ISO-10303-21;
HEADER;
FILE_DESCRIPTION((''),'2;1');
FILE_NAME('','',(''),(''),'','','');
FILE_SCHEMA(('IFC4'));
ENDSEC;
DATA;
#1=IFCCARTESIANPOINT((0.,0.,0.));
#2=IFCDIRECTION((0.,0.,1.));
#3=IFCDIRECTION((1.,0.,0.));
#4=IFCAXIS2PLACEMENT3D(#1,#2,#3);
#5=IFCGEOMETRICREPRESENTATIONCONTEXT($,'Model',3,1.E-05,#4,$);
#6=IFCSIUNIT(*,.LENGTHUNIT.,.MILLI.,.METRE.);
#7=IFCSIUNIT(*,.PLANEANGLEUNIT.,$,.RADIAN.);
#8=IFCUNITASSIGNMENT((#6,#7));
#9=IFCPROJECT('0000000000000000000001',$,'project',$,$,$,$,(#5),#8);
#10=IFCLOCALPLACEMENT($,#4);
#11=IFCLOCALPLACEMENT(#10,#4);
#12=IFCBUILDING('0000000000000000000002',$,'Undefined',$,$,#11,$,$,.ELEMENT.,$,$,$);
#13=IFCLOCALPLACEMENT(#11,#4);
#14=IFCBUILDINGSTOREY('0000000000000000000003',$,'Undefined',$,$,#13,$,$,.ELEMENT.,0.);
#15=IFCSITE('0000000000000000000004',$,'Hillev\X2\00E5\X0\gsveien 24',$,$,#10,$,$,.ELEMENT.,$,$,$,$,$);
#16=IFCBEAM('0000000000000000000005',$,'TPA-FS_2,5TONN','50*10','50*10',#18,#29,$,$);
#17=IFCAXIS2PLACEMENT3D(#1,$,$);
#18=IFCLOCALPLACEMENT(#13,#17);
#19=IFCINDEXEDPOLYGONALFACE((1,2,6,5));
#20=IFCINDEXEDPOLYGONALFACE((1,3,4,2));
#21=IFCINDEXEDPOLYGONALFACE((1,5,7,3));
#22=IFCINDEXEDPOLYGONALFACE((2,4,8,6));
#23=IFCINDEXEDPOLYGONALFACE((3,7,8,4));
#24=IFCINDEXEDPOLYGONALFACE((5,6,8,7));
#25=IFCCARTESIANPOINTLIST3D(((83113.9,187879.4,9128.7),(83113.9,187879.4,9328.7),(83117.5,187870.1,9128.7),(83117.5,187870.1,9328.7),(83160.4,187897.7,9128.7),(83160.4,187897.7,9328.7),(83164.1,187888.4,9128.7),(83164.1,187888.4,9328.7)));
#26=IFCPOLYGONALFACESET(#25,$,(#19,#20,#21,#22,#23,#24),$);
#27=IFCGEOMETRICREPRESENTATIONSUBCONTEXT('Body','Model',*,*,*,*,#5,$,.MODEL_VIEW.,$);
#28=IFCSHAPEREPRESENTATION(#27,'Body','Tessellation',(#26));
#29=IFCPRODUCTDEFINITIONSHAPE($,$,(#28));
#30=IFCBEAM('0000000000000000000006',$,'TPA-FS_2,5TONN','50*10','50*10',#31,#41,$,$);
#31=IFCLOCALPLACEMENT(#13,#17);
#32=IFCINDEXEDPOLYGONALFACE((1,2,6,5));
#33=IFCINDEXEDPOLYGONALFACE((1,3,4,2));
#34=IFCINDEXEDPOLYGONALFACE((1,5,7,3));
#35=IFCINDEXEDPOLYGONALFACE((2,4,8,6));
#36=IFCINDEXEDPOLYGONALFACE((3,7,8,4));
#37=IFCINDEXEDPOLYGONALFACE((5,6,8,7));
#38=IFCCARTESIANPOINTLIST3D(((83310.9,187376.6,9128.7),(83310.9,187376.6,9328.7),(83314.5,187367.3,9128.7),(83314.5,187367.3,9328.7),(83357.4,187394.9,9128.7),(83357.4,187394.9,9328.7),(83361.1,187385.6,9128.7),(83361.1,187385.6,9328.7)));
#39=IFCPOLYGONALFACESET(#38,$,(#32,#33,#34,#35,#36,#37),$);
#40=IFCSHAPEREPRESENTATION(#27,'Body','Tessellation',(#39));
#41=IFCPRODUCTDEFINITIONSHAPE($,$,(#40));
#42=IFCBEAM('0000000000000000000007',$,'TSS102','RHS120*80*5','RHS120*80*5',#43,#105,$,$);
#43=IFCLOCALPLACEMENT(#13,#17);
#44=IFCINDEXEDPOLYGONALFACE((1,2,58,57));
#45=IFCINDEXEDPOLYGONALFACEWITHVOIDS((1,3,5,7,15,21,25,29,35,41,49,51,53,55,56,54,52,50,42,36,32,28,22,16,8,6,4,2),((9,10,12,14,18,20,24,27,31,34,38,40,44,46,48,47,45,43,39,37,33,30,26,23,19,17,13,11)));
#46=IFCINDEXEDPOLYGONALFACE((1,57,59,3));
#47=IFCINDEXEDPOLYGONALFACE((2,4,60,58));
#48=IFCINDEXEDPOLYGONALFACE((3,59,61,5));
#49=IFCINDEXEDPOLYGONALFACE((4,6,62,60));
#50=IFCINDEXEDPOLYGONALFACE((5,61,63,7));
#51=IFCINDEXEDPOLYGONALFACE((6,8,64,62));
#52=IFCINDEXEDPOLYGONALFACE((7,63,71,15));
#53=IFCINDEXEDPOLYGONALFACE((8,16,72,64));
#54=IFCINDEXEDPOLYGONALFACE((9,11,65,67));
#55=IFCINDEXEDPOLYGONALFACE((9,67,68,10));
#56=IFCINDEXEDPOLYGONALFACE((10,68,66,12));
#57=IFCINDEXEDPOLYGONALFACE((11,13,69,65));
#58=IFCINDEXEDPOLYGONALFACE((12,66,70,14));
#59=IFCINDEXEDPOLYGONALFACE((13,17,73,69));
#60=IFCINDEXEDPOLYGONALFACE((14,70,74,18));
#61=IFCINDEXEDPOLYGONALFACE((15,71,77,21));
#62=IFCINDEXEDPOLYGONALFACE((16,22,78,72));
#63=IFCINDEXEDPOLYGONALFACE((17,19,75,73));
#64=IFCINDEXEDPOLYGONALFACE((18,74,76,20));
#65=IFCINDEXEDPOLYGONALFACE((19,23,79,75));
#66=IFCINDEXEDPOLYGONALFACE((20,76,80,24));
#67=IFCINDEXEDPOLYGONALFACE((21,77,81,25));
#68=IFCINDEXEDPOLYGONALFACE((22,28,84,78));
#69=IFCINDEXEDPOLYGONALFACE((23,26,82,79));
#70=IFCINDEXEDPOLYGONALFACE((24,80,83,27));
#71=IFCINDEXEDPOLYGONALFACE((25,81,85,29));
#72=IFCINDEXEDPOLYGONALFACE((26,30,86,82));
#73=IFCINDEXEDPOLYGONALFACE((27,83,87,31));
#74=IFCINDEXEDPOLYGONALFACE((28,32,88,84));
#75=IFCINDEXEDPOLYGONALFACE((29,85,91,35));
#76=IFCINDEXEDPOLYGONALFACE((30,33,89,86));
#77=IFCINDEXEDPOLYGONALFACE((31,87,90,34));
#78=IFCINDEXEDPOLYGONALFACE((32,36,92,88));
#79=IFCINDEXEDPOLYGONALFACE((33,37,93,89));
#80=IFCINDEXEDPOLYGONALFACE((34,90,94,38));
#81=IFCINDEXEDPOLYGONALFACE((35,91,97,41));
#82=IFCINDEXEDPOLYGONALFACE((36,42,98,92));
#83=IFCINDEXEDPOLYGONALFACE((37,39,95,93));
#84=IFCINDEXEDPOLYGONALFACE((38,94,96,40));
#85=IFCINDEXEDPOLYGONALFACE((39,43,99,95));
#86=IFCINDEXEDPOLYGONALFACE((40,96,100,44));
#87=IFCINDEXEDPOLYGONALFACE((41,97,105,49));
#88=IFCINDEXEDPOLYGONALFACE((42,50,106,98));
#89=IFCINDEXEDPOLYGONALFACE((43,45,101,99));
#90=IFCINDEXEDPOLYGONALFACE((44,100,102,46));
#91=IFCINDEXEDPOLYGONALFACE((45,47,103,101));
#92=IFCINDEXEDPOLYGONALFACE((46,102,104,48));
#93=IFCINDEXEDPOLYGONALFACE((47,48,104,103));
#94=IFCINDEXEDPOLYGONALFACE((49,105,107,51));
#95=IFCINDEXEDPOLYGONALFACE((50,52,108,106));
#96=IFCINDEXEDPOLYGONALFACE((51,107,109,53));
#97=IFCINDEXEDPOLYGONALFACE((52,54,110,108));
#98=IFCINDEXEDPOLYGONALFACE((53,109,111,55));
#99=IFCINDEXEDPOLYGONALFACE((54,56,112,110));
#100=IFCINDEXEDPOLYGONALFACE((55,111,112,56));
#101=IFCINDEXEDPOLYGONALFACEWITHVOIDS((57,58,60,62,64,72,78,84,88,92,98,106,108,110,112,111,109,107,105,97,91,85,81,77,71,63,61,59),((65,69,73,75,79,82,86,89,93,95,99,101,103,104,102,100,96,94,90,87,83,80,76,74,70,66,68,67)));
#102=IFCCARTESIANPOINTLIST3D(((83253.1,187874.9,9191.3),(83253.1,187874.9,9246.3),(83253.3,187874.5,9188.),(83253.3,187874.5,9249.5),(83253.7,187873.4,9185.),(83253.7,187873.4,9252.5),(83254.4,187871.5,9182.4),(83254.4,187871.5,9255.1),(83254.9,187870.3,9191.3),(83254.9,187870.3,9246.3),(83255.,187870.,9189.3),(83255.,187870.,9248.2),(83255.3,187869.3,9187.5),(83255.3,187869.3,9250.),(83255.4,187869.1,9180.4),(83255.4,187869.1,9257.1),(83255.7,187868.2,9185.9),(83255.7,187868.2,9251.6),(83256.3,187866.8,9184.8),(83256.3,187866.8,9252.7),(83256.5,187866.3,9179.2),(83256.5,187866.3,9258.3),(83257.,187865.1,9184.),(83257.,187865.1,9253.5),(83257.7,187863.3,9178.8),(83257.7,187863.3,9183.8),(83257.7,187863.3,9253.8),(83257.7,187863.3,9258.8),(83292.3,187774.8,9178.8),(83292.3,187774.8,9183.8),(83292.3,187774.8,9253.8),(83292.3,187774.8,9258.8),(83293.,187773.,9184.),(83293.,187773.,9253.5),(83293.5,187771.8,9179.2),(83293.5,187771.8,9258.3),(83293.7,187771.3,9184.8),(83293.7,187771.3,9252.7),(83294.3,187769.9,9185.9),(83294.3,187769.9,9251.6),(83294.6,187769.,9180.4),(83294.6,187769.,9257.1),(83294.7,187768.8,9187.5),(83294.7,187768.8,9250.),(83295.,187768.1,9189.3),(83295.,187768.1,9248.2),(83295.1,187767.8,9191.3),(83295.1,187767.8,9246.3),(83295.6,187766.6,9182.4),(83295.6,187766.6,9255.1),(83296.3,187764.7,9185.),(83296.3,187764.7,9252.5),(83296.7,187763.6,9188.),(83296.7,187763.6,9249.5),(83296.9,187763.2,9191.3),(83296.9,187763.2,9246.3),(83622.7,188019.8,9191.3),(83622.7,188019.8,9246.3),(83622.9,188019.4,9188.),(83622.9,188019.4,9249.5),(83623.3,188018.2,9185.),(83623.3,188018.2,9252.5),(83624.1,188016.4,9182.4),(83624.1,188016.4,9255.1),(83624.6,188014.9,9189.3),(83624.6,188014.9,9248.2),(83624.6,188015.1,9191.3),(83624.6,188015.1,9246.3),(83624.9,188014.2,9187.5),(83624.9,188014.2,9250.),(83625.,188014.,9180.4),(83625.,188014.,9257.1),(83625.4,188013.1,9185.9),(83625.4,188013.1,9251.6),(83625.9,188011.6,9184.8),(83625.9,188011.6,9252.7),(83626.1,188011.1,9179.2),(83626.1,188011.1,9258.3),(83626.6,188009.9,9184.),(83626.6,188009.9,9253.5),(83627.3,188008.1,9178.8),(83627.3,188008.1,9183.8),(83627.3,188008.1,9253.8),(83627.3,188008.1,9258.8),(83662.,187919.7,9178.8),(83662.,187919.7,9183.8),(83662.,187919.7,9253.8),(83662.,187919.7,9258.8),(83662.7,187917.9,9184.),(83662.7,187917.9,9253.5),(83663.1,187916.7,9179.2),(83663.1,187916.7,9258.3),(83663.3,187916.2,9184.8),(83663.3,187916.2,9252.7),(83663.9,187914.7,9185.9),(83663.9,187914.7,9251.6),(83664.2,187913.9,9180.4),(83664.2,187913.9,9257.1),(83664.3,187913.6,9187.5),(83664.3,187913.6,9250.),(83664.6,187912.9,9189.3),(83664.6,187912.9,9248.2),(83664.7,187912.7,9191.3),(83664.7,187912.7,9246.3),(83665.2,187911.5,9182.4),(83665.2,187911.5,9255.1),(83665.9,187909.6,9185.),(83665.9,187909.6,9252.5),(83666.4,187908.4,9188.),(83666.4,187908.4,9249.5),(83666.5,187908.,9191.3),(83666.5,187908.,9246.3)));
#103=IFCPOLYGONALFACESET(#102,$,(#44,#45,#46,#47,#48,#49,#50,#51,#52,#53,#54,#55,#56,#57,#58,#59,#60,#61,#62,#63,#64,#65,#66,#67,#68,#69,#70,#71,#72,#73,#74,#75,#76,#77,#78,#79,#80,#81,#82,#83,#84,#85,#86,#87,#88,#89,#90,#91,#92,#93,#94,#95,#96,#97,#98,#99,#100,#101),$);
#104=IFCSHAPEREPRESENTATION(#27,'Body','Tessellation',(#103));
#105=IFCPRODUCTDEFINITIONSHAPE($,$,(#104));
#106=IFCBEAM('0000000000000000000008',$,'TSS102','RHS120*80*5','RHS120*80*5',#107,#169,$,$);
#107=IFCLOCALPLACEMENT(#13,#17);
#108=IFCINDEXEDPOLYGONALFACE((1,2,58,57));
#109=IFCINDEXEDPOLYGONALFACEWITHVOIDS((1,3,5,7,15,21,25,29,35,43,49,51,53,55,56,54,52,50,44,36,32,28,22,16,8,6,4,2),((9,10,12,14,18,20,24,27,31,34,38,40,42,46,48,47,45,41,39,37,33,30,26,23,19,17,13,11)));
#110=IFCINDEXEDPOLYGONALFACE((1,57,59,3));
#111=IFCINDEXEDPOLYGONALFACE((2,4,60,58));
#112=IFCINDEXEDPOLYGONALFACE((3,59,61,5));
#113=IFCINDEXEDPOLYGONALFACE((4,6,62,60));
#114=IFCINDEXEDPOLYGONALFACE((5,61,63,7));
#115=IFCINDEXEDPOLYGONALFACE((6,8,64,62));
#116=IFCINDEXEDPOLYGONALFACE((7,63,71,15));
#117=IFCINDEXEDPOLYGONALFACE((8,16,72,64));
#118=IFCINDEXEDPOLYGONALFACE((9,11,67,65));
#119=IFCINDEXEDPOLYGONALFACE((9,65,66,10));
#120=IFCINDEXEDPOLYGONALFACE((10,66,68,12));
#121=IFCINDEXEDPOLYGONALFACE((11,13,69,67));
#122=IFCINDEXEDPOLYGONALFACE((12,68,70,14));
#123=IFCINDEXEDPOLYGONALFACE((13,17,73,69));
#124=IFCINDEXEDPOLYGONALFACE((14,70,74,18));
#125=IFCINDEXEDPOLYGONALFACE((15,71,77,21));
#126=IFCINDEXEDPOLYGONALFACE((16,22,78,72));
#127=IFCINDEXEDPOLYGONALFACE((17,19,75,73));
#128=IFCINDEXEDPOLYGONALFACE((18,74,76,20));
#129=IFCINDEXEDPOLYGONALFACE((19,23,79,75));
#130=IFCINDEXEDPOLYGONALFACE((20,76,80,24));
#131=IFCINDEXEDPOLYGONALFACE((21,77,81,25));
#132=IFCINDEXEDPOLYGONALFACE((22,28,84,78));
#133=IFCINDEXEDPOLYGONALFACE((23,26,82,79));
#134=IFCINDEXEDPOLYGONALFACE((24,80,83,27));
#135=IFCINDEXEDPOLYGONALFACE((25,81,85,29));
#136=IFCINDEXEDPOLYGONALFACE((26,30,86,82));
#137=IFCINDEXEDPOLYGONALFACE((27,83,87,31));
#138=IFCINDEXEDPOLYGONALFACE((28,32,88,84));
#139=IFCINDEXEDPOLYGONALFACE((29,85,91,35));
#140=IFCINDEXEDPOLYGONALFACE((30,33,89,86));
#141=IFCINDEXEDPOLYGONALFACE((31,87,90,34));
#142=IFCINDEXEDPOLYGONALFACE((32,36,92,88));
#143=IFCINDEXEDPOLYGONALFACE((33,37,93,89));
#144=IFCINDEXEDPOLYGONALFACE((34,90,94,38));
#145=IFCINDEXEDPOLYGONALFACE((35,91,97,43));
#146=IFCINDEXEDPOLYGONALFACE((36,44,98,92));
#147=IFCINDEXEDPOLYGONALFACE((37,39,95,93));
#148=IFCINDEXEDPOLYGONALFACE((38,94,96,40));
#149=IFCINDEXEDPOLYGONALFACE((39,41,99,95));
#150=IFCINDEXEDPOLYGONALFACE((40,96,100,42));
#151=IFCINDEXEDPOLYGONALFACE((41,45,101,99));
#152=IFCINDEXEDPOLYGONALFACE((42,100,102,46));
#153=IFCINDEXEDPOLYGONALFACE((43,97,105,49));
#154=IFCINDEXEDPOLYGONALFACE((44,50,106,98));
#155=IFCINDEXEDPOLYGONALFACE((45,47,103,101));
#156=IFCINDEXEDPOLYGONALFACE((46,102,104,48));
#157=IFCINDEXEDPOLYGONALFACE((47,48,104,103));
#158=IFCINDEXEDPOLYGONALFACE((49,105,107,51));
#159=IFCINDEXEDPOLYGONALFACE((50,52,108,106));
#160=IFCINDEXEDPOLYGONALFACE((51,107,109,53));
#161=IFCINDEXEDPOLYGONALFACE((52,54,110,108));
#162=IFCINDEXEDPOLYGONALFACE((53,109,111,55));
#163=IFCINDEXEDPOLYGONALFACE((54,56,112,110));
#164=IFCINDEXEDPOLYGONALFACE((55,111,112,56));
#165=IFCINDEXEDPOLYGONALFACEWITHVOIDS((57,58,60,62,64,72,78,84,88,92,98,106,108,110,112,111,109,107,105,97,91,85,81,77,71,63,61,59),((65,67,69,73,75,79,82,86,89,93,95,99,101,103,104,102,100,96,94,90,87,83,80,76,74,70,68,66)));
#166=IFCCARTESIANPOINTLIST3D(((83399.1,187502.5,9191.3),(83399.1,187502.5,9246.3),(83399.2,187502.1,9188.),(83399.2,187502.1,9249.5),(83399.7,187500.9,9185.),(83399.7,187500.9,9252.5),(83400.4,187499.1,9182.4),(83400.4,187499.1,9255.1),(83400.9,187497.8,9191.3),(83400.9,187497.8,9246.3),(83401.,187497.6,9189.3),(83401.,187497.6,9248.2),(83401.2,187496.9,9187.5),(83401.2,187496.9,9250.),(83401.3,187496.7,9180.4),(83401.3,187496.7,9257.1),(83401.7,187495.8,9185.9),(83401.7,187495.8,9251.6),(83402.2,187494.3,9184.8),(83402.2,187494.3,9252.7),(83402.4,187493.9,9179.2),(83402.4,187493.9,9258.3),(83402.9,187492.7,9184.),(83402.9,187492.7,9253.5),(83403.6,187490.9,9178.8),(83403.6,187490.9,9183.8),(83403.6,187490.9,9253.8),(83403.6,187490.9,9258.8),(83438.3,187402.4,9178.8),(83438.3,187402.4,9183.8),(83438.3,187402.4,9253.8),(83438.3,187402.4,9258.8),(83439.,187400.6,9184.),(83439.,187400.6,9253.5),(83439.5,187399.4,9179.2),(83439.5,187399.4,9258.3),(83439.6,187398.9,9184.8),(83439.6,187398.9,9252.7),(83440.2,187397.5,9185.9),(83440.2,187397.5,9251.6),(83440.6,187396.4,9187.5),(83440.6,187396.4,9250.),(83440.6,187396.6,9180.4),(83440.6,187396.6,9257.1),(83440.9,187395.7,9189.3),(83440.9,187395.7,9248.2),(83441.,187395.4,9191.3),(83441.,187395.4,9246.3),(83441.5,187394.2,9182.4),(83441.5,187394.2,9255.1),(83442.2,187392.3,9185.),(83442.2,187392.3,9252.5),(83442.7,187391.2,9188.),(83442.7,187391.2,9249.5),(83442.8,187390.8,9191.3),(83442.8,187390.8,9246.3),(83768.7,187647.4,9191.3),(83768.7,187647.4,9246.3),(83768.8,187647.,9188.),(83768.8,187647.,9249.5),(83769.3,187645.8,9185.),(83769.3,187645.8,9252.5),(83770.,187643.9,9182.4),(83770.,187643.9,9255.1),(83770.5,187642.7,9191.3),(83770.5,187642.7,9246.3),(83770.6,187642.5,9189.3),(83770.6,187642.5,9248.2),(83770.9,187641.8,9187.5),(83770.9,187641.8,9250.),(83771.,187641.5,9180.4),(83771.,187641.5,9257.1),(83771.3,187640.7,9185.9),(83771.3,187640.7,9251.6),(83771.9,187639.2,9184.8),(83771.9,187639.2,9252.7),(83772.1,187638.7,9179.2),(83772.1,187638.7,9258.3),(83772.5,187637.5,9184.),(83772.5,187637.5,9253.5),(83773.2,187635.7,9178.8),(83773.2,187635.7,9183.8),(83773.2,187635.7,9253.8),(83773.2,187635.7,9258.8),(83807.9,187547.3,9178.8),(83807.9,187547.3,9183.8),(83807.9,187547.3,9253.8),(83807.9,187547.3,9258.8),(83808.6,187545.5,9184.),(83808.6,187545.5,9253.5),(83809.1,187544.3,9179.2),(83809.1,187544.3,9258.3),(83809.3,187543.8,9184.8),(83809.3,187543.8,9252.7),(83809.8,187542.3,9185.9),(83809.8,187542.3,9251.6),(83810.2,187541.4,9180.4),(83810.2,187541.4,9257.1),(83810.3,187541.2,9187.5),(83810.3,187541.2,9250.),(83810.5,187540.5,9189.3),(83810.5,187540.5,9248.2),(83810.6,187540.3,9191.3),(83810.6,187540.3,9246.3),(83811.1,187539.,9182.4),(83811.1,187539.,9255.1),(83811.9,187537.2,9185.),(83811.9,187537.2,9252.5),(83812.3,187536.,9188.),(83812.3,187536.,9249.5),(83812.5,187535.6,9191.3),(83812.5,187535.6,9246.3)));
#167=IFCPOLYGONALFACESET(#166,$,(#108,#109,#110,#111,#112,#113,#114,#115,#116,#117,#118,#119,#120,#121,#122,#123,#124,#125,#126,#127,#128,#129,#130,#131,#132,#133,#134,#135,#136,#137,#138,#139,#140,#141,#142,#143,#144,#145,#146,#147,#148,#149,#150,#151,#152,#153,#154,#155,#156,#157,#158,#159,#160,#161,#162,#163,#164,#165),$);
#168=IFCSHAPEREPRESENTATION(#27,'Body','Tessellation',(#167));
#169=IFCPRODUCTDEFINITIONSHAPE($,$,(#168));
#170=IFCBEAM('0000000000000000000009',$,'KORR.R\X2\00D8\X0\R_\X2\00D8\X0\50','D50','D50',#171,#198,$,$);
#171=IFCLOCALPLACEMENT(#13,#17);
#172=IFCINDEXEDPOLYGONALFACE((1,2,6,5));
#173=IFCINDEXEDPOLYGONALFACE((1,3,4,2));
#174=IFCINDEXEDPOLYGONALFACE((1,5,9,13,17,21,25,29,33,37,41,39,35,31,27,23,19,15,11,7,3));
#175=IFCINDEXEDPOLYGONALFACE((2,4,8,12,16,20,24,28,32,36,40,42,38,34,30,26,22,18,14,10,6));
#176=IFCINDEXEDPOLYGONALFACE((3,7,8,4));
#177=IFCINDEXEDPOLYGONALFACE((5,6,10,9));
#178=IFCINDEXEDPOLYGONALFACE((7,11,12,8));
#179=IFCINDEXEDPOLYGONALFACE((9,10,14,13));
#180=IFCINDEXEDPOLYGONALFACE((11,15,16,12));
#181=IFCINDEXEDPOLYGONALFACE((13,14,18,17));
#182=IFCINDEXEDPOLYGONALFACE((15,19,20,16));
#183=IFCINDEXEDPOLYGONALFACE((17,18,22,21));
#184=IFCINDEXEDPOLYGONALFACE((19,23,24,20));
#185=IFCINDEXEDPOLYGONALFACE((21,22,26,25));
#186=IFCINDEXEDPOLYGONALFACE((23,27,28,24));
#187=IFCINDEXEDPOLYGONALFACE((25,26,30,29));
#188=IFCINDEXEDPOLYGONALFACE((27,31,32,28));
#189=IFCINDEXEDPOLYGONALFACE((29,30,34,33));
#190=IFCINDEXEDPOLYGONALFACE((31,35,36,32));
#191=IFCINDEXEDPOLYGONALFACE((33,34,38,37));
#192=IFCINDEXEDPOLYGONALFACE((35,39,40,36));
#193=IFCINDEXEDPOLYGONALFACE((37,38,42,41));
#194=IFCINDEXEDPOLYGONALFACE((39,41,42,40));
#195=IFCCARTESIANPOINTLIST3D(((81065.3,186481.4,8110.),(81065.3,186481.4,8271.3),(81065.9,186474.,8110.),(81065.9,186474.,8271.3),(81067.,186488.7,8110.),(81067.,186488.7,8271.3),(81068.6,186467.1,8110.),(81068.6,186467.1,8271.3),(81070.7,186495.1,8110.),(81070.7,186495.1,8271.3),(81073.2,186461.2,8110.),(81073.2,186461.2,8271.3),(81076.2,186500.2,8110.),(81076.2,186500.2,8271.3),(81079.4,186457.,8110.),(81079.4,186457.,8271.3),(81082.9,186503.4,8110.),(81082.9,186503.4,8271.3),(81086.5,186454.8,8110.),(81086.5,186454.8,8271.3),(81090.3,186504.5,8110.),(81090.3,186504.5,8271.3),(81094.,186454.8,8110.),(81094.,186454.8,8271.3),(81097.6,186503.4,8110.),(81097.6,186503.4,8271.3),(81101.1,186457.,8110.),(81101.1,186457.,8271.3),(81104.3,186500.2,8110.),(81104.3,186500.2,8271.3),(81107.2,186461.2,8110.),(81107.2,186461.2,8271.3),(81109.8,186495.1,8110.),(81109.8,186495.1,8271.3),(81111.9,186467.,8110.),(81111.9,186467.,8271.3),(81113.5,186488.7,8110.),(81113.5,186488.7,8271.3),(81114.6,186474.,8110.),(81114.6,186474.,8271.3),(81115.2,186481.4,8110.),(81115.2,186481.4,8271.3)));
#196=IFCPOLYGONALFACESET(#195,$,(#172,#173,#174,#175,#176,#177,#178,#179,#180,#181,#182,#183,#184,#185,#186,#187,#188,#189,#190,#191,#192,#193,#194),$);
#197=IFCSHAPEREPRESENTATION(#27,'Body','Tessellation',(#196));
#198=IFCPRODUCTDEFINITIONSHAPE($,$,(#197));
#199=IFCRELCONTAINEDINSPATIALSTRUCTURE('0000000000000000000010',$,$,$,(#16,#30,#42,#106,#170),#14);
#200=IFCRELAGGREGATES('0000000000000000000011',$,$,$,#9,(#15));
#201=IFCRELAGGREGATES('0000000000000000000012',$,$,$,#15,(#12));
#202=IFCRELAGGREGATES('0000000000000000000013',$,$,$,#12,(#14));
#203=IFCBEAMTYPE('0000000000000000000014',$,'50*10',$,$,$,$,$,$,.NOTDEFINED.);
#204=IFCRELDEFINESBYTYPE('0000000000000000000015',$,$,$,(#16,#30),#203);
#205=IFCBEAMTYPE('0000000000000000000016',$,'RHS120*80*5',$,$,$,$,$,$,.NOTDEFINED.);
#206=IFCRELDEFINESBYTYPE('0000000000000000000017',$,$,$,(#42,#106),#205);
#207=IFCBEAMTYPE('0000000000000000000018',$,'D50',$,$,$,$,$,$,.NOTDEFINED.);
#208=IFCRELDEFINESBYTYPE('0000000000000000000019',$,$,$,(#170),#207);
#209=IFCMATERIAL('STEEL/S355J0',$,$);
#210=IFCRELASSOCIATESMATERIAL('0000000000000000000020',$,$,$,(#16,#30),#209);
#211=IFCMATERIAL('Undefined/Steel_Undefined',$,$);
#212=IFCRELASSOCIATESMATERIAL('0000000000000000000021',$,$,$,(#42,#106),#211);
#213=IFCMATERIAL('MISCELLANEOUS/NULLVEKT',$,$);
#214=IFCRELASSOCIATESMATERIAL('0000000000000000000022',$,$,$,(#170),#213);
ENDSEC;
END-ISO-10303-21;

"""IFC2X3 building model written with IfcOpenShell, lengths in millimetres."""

from ifc_helpers import new_model, si_unit, frame, frame_2d, origin_with_axes, place, context, subcontext, project, spatial, rectangle, hollow_rectangle, circle, extrude, material, type_object, element, save


model = new_model("IFC2X3")

# Units and contexts
model_context = context("Model", 3, precision=1e-05, world=origin_with_axes())
body_context = subcontext(model_context, "Body", "Model", "MODEL_VIEW")
ifc_project = project(units=[si_unit("LENGTHUNIT", "METRE", prefix="MILLI"), si_unit("PLANEANGLEUNIT", "RADIAN")], contexts=[model_context])

# Site, building, storey
site_placement = place(None, origin_with_axes())
site = spatial("IfcSite", under=ifc_project, at=site_placement, Name="Hillevågsveien 24", CompositionType="ELEMENT")
building_placement = place(site_placement, origin_with_axes())
building = spatial("IfcBuilding", under=site, at=building_placement, Name="Undefined", CompositionType="ELEMENT")
storey_placement = place(building_placement, origin_with_axes())
storey = spatial("IfcBuildingStorey", under=building, at=storey_placement, Name="Undefined", CompositionType="ELEMENT", Elevation=0.0)

# Shared definitions
ifc_material_1 = material(Name="STEEL/S355J0")

# Beams
ifc_material_2 = material(Name="Undefined/Steel_Undefined")
beam_type_1 = type_object("IfcBeamType", Name="50*10", PredefinedType="NOTDEFINED")
for number, where, z_axis, x_axis, name in (
    (1, (83139.0, 187883.9, 9328.7), (0.931056, 0.364877, 0.0), (0.0, 0.0, -1.0), "TPA-FS_2,5TONN"),
    (2, (83336.0, 187381.1, 9328.7), (0.931056, 0.364877, 0.0), (0.0, 0.0, -1.0), "TPA-FS_2,5TONN"),
):
    element("IfcBeam", number, at=place(storey_placement, frame(where, z_axis=z_axis, x_axis=x_axis)), inside=storey, type_object=beam_type_1, material=ifc_material_1, Name=name, Description="50*10", ObjectType="50*10", context=body_context, shape_type="SweptSolid", body=[
        extrude(rectangle(XDim=10.0, YDim=50.0, at=frame_2d((0.0, 0.0), x_axis=(1.0, 0.0))), frame((200.0, 0.0, 0.0), z_axis=(-1.0, 0.0, 0.0), x_axis=(0.0, -1.0, 0.0)), (0.0, 0.0, 1.0), 200.0),
    ])
beam_type_2 = type_object("IfcBeamType", Name="RHS120*80*5", PredefinedType="NOTDEFINED")
for number, where, z_axis, x_axis, name in (
    (3, (83644.6, 187963.9, 9218.8), (0.364887, -0.931052, 0.0), (-0.931052, -0.364887, 0.0), "TSS102"),
    (4, (83790.6, 187591.5, 9218.8), (0.364887, -0.931052, 0.0), (-0.931052, -0.364887, 0.0), "TSS102"),
):
    element("IfcBeam", number, at=place(storey_placement, frame(where, z_axis=z_axis, x_axis=x_axis)), inside=storey, type_object=beam_type_2, material=ifc_material_2, Name=name, Description="RHS120*80*5", ObjectType="RHS120*80*5", context=body_context, shape_type="SweptSolid", body=[
        extrude(hollow_rectangle(XDim=80.0, YDim=120.0, WallThickness=5.0, InnerFilletRadius=7.5, OuterFilletRadius=12.5, at=frame_2d((0.0, 0.0), x_axis=(1.0, 0.0))), frame((397.0, 0.0, 0.0), z_axis=(-1.0, 0.0, 0.0), x_axis=(0.0, -1.0, 0.0)), (0.0, 0.0, 1.0), 397.0),
    ])
ifc_material_3 = material(Name="MISCELLANEOUS/NULLVEKT")
beam_type_3 = type_object("IfcBeamType", Name="D50", PredefinedType="NOTDEFINED")
beam_placement = place(storey_placement, frame((81090.2, 186479.5, 8271.3), z_axis=(-0.364877, 0.931056, 0.0), x_axis=(0.0, 0.0, -1.0)))
element("IfcBeam", 5, at=beam_placement, inside=storey, type_object=beam_type_3, material=ifc_material_3, Name="KORR.RØR_Ø50", Description="D50", ObjectType="D50", context=body_context, shape_type="SweptSolid", body=[
    extrude(circle(Radius=25.0, at=frame_2d((0.0, 0.0), x_axis=(1.0, 0.0))), frame((161.2, 0.0, 0.0), z_axis=(-1.0, 0.0, 0.0), x_axis=(0.0, -1.0, 0.0)), (0.0, 0.0, 1.0), 161.2),
])

save(model, "model.ifc")
